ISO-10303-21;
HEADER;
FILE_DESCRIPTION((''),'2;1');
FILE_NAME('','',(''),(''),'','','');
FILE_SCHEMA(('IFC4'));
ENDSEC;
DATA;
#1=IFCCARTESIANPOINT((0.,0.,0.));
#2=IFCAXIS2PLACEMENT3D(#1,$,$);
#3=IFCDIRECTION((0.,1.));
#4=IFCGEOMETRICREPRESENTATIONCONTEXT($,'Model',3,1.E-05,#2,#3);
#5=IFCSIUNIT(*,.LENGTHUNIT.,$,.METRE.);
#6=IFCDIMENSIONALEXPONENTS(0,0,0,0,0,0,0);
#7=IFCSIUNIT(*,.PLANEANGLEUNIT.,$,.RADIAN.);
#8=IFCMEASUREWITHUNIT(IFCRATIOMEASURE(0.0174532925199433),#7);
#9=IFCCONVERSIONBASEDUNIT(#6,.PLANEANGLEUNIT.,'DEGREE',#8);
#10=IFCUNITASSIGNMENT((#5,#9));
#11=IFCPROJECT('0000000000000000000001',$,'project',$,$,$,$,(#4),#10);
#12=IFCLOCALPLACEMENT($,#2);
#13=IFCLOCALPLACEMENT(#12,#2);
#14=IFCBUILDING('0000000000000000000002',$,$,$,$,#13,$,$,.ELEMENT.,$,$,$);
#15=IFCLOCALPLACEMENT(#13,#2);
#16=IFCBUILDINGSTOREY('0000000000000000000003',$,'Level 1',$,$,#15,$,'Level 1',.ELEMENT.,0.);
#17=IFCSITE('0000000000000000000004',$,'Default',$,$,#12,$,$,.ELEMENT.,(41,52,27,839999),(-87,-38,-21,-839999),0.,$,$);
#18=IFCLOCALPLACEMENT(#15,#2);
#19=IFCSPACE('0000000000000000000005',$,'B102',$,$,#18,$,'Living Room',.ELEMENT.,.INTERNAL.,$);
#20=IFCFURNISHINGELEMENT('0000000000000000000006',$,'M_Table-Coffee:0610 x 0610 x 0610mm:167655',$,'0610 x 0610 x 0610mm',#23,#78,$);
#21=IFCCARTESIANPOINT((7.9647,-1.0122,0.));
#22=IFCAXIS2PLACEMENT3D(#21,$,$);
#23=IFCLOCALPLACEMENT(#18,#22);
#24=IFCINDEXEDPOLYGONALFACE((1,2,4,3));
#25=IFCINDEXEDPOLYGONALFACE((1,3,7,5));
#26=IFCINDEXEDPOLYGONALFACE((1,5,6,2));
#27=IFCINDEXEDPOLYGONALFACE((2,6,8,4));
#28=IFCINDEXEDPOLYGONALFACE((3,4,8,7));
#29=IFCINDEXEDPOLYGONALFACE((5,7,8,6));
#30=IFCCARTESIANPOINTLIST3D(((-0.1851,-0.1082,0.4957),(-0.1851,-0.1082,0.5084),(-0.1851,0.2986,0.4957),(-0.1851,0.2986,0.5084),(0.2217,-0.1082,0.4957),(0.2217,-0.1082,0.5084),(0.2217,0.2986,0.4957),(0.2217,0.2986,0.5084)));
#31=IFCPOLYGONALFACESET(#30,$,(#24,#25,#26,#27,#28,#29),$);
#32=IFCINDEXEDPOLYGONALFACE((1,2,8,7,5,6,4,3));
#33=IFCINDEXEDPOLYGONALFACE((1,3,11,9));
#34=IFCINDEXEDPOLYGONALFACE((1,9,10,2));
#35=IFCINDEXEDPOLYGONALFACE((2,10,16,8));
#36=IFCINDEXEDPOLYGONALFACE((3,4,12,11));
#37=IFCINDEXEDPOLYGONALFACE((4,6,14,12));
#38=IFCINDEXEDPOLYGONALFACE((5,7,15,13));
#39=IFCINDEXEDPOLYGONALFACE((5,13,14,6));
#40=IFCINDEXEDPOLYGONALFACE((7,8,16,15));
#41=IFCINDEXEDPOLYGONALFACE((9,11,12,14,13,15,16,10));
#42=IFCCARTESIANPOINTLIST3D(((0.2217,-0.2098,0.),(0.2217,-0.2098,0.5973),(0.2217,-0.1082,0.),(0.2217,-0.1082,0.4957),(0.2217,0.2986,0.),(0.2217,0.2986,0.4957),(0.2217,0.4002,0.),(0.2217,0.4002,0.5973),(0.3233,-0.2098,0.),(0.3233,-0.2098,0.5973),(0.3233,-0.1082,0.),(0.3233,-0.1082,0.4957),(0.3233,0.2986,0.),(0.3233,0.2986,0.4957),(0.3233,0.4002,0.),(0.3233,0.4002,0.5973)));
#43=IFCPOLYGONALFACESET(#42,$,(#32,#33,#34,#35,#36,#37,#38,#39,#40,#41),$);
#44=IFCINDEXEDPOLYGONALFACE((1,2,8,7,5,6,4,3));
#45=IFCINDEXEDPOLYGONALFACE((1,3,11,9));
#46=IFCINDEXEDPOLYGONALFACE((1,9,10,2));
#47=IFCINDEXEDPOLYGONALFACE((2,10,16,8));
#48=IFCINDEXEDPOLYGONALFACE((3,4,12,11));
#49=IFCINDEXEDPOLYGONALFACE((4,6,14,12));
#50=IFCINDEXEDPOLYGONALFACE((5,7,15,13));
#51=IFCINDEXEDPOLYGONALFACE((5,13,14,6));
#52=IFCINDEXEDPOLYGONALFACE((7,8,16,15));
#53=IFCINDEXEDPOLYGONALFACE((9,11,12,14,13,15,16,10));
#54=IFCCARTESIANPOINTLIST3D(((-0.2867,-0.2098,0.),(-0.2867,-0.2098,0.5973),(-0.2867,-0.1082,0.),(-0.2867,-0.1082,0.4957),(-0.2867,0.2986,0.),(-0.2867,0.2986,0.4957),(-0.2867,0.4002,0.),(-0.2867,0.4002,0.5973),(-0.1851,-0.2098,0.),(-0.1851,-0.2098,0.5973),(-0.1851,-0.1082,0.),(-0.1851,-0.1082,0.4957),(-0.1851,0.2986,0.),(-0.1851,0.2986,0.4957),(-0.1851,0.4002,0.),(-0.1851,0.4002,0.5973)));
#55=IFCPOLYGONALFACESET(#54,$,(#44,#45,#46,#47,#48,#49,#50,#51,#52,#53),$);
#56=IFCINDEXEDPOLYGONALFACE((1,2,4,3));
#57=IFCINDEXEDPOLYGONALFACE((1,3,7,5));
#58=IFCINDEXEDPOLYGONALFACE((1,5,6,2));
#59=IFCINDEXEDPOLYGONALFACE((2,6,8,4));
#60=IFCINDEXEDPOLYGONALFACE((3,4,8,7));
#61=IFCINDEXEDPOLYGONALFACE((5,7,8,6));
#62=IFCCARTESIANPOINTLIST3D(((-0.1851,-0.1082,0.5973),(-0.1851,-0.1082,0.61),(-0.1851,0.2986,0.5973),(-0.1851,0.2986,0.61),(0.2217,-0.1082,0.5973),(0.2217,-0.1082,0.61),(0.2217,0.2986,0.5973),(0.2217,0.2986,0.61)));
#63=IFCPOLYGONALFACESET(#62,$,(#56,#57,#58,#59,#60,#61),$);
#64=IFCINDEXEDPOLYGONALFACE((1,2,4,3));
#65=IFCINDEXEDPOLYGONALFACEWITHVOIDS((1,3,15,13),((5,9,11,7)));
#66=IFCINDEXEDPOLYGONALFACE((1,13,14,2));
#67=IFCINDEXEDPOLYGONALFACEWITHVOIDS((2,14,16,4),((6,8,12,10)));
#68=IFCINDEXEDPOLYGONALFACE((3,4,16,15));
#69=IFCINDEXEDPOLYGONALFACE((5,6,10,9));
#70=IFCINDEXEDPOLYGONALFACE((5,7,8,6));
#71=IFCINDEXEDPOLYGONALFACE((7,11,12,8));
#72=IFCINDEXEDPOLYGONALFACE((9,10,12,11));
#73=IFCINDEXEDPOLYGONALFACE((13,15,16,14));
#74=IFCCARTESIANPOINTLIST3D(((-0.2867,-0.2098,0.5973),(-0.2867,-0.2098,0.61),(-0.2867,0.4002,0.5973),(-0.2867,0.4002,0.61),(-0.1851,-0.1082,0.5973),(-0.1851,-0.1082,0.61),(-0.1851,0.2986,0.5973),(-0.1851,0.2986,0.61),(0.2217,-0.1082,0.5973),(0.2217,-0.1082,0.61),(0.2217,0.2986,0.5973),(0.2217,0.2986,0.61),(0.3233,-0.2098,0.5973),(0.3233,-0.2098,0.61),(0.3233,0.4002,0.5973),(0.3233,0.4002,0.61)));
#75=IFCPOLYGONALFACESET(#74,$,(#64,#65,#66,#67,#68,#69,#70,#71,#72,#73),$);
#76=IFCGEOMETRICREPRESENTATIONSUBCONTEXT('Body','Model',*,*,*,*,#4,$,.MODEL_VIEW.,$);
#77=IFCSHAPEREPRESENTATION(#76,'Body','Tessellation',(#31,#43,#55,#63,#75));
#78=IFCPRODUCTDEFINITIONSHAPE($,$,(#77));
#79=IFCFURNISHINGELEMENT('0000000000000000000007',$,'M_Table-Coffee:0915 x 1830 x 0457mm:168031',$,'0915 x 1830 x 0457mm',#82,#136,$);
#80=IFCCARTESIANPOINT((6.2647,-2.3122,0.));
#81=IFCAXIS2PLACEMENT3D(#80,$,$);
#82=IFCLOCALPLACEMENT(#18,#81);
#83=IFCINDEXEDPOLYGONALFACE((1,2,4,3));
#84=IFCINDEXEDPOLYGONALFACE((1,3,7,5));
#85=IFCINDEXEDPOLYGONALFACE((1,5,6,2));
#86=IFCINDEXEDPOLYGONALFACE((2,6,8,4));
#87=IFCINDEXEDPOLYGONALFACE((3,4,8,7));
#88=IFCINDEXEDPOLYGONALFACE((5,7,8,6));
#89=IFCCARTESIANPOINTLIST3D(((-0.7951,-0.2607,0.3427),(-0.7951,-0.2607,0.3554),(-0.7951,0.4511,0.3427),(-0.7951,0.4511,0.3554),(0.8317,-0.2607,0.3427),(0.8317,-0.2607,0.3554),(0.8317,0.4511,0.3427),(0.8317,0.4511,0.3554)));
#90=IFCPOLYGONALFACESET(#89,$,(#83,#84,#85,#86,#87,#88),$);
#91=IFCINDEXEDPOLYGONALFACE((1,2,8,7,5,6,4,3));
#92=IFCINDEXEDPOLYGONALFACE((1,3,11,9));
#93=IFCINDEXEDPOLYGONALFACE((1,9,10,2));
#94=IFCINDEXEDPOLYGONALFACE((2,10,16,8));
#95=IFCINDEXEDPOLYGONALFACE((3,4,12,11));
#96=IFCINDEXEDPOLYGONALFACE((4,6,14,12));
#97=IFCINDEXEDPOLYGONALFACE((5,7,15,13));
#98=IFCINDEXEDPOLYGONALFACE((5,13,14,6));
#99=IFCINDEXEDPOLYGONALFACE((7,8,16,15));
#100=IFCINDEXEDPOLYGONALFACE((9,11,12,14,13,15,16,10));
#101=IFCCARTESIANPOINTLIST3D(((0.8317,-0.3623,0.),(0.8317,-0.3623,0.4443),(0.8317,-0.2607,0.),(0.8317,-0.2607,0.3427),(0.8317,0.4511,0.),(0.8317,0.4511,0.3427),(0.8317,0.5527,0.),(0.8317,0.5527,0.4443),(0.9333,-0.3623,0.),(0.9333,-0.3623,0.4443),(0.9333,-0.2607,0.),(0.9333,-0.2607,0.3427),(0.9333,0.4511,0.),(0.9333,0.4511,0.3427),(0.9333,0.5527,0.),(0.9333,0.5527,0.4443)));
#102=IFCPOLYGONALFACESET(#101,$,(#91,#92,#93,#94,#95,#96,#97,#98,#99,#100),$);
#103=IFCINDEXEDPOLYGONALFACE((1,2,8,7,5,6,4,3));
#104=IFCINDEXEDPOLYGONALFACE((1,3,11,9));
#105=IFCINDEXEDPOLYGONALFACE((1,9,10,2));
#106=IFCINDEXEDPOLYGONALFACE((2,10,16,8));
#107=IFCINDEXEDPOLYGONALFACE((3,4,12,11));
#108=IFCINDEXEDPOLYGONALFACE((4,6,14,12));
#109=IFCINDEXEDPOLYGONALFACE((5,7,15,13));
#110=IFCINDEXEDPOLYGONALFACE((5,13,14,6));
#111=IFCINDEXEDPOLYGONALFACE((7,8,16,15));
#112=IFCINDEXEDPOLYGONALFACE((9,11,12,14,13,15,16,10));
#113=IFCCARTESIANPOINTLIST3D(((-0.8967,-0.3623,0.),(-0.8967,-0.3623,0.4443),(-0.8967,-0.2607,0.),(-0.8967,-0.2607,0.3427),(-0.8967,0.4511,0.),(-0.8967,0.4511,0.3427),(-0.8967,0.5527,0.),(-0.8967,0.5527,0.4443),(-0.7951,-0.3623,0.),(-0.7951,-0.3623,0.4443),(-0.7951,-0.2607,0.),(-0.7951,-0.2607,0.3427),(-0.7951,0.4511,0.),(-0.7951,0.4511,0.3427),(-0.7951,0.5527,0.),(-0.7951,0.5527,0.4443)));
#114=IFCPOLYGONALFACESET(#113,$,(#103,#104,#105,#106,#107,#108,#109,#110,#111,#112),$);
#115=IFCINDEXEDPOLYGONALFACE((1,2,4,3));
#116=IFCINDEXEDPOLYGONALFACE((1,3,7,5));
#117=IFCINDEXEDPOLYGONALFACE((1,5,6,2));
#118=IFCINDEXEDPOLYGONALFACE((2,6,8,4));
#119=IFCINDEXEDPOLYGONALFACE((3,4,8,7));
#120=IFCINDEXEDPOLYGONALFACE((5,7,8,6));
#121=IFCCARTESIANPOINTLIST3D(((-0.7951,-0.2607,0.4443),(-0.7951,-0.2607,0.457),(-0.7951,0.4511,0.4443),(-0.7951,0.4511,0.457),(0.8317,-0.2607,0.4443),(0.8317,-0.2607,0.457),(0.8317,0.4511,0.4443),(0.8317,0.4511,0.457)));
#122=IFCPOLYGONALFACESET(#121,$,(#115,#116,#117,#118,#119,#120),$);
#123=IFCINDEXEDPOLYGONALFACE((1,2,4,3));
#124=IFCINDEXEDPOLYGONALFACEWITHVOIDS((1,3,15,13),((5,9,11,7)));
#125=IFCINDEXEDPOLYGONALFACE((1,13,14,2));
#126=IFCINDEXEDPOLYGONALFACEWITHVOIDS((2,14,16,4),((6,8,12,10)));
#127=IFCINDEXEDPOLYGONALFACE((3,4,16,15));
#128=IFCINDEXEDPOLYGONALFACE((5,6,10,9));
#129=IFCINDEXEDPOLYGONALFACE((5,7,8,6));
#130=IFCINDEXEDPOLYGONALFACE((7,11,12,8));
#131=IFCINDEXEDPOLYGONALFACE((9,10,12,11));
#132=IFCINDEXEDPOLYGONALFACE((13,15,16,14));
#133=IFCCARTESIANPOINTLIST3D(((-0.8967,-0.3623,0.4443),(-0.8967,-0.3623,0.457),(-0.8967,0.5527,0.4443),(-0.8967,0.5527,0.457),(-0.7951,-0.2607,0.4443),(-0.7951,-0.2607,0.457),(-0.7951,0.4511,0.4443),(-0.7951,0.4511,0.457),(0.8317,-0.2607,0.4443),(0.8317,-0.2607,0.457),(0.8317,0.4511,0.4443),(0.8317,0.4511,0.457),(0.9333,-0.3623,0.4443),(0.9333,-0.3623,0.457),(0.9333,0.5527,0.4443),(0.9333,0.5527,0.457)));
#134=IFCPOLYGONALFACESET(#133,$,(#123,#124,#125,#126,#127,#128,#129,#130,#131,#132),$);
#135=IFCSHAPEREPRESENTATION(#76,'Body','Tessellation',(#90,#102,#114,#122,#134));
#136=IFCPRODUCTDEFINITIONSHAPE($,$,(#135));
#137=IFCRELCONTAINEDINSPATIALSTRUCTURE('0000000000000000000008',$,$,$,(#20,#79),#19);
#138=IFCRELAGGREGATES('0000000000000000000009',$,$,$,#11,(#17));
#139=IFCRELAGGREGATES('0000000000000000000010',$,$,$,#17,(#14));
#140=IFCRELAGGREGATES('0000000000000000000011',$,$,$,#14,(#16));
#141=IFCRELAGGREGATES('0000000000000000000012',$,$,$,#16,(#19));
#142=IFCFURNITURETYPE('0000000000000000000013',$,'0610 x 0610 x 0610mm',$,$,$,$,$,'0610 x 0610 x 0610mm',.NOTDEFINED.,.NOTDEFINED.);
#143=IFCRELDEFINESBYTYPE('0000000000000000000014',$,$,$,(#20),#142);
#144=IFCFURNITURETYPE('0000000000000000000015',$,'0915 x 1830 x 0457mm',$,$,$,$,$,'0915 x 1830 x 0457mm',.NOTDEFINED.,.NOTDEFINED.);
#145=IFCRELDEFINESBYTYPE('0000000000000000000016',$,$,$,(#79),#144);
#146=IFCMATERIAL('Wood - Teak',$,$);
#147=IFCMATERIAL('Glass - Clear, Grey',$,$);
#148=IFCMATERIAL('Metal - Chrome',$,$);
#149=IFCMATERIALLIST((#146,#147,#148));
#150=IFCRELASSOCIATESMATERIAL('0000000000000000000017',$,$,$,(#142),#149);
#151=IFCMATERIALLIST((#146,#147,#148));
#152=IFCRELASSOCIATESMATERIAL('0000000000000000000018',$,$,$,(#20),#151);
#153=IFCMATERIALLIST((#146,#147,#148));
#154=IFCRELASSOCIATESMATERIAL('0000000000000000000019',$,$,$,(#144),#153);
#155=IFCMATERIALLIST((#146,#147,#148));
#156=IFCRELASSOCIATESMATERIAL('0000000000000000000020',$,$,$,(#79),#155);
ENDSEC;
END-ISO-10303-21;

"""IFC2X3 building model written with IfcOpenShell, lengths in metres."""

from ifc_helpers import new_model, entity, si_unit, converted_unit, direction, frame, origin, origin_2d_with_axis, place, context, subcontext, project, spatial, polyline, rectangle, outline, extrude, source, transform, mapped, material, material_list, type_object, type_shapes, element, save


model = new_model("IFC2X3")

# Units and contexts
model_context = context("Model", 3, precision=1e-05, world=origin(), true_north=direction((0.0, 1.0)))
body_context = subcontext(model_context, "Body", "Model", "MODEL_VIEW")
ifc_project = project(units=[si_unit("LENGTHUNIT", "METRE"), converted_unit("PLANEANGLEUNIT", "DEGREE", entity("IfcRatioMeasure", 0.0174532925199433), si_unit("PLANEANGLEUNIT", "RADIAN"), dimensions=[0, 0, 0, 0, 0, 0, 0])], contexts=[model_context])

# Site, building, storey
site_placement = place(None, origin())
site = spatial("IfcSite", under=ifc_project, at=site_placement, Name="Default", CompositionType="ELEMENT", RefLatitude=(41, 52, 27, 839999), RefLongitude=(-87, -38, -21, -839999), RefElevation=0.0)
building_placement = place(site_placement, origin())
building = spatial("IfcBuilding", under=site, at=building_placement, CompositionType="ELEMENT")
storey_placement = place(building_placement, origin())
storey = spatial("IfcBuildingStorey", under=building, at=storey_placement, Name="Level 1", LongName="Level 1", CompositionType="ELEMENT", Elevation=0.0)

# Shared definitions
space_1_placement = place(storey_placement, origin())
space_1 = spatial("IfcSpace", under=storey, at=space_1_placement, Name="B102", LongName="Living Room", CompositionType="ELEMENT", InteriorOrExteriorSpace="INTERNAL")

# Furnishing elements
ifc_material_1 = material(Name="Wood - Teak")
ifc_material_2 = material(Name="Glass - Clear, Grey")
ifc_material_3 = material(Name="Metal - Chrome")
ifc_material_list_1 = material_list([ifc_material_1, ifc_material_2, ifc_material_3])
ifc_material_list_2 = material_list([ifc_material_1, ifc_material_2, ifc_material_3])
furniture_type_1 = type_object("IfcFurnitureType", Name="0610 x 0610 x 0610mm", ElementType="0610 x 0610 x 0610mm", material=ifc_material_list_2)
shared_shape_1 = source(origin(), body_context, "Body", "SweptSolid", [
    extrude(rectangle(XDim=0.4068, YDim=0.4068, at=origin_2d_with_axis()), frame((0.0183, 0.0952, 0.4957), z_axis=(0.0, 0.0, 1.0), x_axis=(-1.0, 0.0, 0.0)), (0.0, 0.0, 1.0), 0.0127),
    extrude(outline(polyline([(-0.2732, -0.305), (0.324, -0.305), (0.324, 0.305), (-0.2732, 0.305), (-0.2732, 0.2034), (0.2225, 0.2034), (0.2225, -0.2034), (-0.2732, -0.2034), (-0.2732, -0.305)])), frame((0.2217, 0.0952, 0.2732), z_axis=(1.0, 0.0, 0.0), x_axis=(0.0, 0.0, 1.0)), (0.0, 0.0, 1.0), 0.1016),
    extrude(outline(polyline([(-0.305, -0.3241), (0.305, -0.3241), (0.305, 0.2733), (0.2034, 0.2733), (0.2034, -0.2224), (-0.2034, -0.2224), (-0.2034, 0.2733), (-0.305, 0.2733), (-0.305, -0.3241)])), frame((-0.2867, 0.0952, 0.2733), z_axis=(1.0, 0.0, 0.0), x_axis=(0.0, -1.0, 0.0)), (0.0, 0.0, 1.0), 0.1016),
    extrude(rectangle(XDim=0.4068, YDim=0.4068, at=origin_2d_with_axis()), frame((0.0183, 0.0952, 0.5973), z_axis=(0.0, 0.0, 1.0), x_axis=(-1.0, 0.0, 0.0)), (0.0, 0.0, 1.0), 0.0127),
    extrude(outline(polyline([(-0.305, -0.305), (0.305, -0.305), (0.305, 0.305), (-0.305, 0.305), (-0.305, -0.305)]), holes=[polyline([(-0.2034, -0.2034), (-0.2034, 0.2034), (0.2034, 0.2034), (0.2034, -0.2034), (-0.2034, -0.2034)])]), frame((0.0183, 0.0952, 0.5973), z_axis=(0.0, 0.0, 1.0), x_axis=(-1.0, 0.0, 0.0)), (0.0, 0.0, 1.0), 0.0127),
])
type_shapes(furniture_type_1, [shared_shape_1])
furnishing_1_placement = place(space_1_placement, frame((7.9647, -1.0122, 0.0)))
element("IfcFurnishingElement", 1, at=furnishing_1_placement, inside=space_1, type_object=furniture_type_1, material=ifc_material_list_1, Name="M_Table-Coffee:0610 x 0610 x 0610mm:167655", ObjectType="0610 x 0610 x 0610mm", context=body_context, shape_type="MappedRepresentation", body=[
    mapped(shared_shape_1, transform((0.0, 0.0, 0.0), scale=1.0)),
])
ifc_material_list_3 = material_list([ifc_material_1, ifc_material_2, ifc_material_3])
ifc_material_list_4 = material_list([ifc_material_1, ifc_material_2, ifc_material_3])
furniture_type_2 = type_object("IfcFurnitureType", Name="0915 x 1830 x 0457mm", ElementType="0915 x 1830 x 0457mm", material=ifc_material_list_4)
shared_shape_2 = source(origin(), body_context, "Body", "SweptSolid", [
    extrude(rectangle(XDim=1.6268, YDim=0.7118, at=origin_2d_with_axis()), frame((0.0183, 0.0952, 0.3427), z_axis=(0.0, 0.0, 1.0), x_axis=(-1.0, 0.0, 0.0)), (0.0, 0.0, 1.0), 0.0127),
    extrude(outline(polyline([(-0.1967, -0.4575), (0.2475, -0.4575), (0.2475, 0.4575), (-0.1967, 0.4575), (-0.1967, 0.3559), (0.146, 0.3559), (0.146, -0.3559), (-0.1967, -0.3559), (-0.1967, -0.4575)])), frame((0.8317, 0.0952, 0.1967), z_axis=(1.0, 0.0, 0.0), x_axis=(0.0, 0.0, 1.0)), (0.0, 0.0, 1.0), 0.1016),
    extrude(outline(polyline([(-0.4575, -0.2476), (0.4575, -0.2476), (0.4575, 0.1968), (0.3559, 0.1968), (0.3559, -0.1459), (-0.3559, -0.1459), (-0.3559, 0.1968), (-0.4575, 0.1968), (-0.4575, -0.2476)])), frame((-0.8967, 0.0952, 0.1968), z_axis=(1.0, 0.0, 0.0), x_axis=(0.0, -1.0, 0.0)), (0.0, 0.0, 1.0), 0.1016),
    extrude(rectangle(XDim=1.6268, YDim=0.7118, at=origin_2d_with_axis()), frame((0.0183, 0.0952, 0.4443), z_axis=(0.0, 0.0, 1.0), x_axis=(-1.0, 0.0, 0.0)), (0.0, 0.0, 1.0), 0.0127),
    extrude(outline(polyline([(-0.915, -0.4575), (0.915, -0.4575), (0.915, 0.4575), (-0.915, 0.4575), (-0.915, -0.4575)]), holes=[polyline([(-0.8134, -0.3559), (-0.8134, 0.3559), (0.8134, 0.3559), (0.8134, -0.3559), (-0.8134, -0.3559)])]), frame((0.0183, 0.0952, 0.4443), z_axis=(0.0, 0.0, 1.0), x_axis=(-1.0, 0.0, 0.0)), (0.0, 0.0, 1.0), 0.0127),
])
type_shapes(furniture_type_2, [shared_shape_2])
furnishing_2_placement = place(space_1_placement, frame((6.2647, -2.3122, 0.0)))
element("IfcFurnishingElement", 2, at=furnishing_2_placement, inside=space_1, type_object=furniture_type_2, material=ifc_material_list_3, Name="M_Table-Coffee:0915 x 1830 x 0457mm:168031", ObjectType="0915 x 1830 x 0457mm", context=body_context, shape_type="MappedRepresentation", body=[
    mapped(shared_shape_2, transform((0.0, 0.0, 0.0), scale=1.0)),
])

save(model, "model.ifc")
